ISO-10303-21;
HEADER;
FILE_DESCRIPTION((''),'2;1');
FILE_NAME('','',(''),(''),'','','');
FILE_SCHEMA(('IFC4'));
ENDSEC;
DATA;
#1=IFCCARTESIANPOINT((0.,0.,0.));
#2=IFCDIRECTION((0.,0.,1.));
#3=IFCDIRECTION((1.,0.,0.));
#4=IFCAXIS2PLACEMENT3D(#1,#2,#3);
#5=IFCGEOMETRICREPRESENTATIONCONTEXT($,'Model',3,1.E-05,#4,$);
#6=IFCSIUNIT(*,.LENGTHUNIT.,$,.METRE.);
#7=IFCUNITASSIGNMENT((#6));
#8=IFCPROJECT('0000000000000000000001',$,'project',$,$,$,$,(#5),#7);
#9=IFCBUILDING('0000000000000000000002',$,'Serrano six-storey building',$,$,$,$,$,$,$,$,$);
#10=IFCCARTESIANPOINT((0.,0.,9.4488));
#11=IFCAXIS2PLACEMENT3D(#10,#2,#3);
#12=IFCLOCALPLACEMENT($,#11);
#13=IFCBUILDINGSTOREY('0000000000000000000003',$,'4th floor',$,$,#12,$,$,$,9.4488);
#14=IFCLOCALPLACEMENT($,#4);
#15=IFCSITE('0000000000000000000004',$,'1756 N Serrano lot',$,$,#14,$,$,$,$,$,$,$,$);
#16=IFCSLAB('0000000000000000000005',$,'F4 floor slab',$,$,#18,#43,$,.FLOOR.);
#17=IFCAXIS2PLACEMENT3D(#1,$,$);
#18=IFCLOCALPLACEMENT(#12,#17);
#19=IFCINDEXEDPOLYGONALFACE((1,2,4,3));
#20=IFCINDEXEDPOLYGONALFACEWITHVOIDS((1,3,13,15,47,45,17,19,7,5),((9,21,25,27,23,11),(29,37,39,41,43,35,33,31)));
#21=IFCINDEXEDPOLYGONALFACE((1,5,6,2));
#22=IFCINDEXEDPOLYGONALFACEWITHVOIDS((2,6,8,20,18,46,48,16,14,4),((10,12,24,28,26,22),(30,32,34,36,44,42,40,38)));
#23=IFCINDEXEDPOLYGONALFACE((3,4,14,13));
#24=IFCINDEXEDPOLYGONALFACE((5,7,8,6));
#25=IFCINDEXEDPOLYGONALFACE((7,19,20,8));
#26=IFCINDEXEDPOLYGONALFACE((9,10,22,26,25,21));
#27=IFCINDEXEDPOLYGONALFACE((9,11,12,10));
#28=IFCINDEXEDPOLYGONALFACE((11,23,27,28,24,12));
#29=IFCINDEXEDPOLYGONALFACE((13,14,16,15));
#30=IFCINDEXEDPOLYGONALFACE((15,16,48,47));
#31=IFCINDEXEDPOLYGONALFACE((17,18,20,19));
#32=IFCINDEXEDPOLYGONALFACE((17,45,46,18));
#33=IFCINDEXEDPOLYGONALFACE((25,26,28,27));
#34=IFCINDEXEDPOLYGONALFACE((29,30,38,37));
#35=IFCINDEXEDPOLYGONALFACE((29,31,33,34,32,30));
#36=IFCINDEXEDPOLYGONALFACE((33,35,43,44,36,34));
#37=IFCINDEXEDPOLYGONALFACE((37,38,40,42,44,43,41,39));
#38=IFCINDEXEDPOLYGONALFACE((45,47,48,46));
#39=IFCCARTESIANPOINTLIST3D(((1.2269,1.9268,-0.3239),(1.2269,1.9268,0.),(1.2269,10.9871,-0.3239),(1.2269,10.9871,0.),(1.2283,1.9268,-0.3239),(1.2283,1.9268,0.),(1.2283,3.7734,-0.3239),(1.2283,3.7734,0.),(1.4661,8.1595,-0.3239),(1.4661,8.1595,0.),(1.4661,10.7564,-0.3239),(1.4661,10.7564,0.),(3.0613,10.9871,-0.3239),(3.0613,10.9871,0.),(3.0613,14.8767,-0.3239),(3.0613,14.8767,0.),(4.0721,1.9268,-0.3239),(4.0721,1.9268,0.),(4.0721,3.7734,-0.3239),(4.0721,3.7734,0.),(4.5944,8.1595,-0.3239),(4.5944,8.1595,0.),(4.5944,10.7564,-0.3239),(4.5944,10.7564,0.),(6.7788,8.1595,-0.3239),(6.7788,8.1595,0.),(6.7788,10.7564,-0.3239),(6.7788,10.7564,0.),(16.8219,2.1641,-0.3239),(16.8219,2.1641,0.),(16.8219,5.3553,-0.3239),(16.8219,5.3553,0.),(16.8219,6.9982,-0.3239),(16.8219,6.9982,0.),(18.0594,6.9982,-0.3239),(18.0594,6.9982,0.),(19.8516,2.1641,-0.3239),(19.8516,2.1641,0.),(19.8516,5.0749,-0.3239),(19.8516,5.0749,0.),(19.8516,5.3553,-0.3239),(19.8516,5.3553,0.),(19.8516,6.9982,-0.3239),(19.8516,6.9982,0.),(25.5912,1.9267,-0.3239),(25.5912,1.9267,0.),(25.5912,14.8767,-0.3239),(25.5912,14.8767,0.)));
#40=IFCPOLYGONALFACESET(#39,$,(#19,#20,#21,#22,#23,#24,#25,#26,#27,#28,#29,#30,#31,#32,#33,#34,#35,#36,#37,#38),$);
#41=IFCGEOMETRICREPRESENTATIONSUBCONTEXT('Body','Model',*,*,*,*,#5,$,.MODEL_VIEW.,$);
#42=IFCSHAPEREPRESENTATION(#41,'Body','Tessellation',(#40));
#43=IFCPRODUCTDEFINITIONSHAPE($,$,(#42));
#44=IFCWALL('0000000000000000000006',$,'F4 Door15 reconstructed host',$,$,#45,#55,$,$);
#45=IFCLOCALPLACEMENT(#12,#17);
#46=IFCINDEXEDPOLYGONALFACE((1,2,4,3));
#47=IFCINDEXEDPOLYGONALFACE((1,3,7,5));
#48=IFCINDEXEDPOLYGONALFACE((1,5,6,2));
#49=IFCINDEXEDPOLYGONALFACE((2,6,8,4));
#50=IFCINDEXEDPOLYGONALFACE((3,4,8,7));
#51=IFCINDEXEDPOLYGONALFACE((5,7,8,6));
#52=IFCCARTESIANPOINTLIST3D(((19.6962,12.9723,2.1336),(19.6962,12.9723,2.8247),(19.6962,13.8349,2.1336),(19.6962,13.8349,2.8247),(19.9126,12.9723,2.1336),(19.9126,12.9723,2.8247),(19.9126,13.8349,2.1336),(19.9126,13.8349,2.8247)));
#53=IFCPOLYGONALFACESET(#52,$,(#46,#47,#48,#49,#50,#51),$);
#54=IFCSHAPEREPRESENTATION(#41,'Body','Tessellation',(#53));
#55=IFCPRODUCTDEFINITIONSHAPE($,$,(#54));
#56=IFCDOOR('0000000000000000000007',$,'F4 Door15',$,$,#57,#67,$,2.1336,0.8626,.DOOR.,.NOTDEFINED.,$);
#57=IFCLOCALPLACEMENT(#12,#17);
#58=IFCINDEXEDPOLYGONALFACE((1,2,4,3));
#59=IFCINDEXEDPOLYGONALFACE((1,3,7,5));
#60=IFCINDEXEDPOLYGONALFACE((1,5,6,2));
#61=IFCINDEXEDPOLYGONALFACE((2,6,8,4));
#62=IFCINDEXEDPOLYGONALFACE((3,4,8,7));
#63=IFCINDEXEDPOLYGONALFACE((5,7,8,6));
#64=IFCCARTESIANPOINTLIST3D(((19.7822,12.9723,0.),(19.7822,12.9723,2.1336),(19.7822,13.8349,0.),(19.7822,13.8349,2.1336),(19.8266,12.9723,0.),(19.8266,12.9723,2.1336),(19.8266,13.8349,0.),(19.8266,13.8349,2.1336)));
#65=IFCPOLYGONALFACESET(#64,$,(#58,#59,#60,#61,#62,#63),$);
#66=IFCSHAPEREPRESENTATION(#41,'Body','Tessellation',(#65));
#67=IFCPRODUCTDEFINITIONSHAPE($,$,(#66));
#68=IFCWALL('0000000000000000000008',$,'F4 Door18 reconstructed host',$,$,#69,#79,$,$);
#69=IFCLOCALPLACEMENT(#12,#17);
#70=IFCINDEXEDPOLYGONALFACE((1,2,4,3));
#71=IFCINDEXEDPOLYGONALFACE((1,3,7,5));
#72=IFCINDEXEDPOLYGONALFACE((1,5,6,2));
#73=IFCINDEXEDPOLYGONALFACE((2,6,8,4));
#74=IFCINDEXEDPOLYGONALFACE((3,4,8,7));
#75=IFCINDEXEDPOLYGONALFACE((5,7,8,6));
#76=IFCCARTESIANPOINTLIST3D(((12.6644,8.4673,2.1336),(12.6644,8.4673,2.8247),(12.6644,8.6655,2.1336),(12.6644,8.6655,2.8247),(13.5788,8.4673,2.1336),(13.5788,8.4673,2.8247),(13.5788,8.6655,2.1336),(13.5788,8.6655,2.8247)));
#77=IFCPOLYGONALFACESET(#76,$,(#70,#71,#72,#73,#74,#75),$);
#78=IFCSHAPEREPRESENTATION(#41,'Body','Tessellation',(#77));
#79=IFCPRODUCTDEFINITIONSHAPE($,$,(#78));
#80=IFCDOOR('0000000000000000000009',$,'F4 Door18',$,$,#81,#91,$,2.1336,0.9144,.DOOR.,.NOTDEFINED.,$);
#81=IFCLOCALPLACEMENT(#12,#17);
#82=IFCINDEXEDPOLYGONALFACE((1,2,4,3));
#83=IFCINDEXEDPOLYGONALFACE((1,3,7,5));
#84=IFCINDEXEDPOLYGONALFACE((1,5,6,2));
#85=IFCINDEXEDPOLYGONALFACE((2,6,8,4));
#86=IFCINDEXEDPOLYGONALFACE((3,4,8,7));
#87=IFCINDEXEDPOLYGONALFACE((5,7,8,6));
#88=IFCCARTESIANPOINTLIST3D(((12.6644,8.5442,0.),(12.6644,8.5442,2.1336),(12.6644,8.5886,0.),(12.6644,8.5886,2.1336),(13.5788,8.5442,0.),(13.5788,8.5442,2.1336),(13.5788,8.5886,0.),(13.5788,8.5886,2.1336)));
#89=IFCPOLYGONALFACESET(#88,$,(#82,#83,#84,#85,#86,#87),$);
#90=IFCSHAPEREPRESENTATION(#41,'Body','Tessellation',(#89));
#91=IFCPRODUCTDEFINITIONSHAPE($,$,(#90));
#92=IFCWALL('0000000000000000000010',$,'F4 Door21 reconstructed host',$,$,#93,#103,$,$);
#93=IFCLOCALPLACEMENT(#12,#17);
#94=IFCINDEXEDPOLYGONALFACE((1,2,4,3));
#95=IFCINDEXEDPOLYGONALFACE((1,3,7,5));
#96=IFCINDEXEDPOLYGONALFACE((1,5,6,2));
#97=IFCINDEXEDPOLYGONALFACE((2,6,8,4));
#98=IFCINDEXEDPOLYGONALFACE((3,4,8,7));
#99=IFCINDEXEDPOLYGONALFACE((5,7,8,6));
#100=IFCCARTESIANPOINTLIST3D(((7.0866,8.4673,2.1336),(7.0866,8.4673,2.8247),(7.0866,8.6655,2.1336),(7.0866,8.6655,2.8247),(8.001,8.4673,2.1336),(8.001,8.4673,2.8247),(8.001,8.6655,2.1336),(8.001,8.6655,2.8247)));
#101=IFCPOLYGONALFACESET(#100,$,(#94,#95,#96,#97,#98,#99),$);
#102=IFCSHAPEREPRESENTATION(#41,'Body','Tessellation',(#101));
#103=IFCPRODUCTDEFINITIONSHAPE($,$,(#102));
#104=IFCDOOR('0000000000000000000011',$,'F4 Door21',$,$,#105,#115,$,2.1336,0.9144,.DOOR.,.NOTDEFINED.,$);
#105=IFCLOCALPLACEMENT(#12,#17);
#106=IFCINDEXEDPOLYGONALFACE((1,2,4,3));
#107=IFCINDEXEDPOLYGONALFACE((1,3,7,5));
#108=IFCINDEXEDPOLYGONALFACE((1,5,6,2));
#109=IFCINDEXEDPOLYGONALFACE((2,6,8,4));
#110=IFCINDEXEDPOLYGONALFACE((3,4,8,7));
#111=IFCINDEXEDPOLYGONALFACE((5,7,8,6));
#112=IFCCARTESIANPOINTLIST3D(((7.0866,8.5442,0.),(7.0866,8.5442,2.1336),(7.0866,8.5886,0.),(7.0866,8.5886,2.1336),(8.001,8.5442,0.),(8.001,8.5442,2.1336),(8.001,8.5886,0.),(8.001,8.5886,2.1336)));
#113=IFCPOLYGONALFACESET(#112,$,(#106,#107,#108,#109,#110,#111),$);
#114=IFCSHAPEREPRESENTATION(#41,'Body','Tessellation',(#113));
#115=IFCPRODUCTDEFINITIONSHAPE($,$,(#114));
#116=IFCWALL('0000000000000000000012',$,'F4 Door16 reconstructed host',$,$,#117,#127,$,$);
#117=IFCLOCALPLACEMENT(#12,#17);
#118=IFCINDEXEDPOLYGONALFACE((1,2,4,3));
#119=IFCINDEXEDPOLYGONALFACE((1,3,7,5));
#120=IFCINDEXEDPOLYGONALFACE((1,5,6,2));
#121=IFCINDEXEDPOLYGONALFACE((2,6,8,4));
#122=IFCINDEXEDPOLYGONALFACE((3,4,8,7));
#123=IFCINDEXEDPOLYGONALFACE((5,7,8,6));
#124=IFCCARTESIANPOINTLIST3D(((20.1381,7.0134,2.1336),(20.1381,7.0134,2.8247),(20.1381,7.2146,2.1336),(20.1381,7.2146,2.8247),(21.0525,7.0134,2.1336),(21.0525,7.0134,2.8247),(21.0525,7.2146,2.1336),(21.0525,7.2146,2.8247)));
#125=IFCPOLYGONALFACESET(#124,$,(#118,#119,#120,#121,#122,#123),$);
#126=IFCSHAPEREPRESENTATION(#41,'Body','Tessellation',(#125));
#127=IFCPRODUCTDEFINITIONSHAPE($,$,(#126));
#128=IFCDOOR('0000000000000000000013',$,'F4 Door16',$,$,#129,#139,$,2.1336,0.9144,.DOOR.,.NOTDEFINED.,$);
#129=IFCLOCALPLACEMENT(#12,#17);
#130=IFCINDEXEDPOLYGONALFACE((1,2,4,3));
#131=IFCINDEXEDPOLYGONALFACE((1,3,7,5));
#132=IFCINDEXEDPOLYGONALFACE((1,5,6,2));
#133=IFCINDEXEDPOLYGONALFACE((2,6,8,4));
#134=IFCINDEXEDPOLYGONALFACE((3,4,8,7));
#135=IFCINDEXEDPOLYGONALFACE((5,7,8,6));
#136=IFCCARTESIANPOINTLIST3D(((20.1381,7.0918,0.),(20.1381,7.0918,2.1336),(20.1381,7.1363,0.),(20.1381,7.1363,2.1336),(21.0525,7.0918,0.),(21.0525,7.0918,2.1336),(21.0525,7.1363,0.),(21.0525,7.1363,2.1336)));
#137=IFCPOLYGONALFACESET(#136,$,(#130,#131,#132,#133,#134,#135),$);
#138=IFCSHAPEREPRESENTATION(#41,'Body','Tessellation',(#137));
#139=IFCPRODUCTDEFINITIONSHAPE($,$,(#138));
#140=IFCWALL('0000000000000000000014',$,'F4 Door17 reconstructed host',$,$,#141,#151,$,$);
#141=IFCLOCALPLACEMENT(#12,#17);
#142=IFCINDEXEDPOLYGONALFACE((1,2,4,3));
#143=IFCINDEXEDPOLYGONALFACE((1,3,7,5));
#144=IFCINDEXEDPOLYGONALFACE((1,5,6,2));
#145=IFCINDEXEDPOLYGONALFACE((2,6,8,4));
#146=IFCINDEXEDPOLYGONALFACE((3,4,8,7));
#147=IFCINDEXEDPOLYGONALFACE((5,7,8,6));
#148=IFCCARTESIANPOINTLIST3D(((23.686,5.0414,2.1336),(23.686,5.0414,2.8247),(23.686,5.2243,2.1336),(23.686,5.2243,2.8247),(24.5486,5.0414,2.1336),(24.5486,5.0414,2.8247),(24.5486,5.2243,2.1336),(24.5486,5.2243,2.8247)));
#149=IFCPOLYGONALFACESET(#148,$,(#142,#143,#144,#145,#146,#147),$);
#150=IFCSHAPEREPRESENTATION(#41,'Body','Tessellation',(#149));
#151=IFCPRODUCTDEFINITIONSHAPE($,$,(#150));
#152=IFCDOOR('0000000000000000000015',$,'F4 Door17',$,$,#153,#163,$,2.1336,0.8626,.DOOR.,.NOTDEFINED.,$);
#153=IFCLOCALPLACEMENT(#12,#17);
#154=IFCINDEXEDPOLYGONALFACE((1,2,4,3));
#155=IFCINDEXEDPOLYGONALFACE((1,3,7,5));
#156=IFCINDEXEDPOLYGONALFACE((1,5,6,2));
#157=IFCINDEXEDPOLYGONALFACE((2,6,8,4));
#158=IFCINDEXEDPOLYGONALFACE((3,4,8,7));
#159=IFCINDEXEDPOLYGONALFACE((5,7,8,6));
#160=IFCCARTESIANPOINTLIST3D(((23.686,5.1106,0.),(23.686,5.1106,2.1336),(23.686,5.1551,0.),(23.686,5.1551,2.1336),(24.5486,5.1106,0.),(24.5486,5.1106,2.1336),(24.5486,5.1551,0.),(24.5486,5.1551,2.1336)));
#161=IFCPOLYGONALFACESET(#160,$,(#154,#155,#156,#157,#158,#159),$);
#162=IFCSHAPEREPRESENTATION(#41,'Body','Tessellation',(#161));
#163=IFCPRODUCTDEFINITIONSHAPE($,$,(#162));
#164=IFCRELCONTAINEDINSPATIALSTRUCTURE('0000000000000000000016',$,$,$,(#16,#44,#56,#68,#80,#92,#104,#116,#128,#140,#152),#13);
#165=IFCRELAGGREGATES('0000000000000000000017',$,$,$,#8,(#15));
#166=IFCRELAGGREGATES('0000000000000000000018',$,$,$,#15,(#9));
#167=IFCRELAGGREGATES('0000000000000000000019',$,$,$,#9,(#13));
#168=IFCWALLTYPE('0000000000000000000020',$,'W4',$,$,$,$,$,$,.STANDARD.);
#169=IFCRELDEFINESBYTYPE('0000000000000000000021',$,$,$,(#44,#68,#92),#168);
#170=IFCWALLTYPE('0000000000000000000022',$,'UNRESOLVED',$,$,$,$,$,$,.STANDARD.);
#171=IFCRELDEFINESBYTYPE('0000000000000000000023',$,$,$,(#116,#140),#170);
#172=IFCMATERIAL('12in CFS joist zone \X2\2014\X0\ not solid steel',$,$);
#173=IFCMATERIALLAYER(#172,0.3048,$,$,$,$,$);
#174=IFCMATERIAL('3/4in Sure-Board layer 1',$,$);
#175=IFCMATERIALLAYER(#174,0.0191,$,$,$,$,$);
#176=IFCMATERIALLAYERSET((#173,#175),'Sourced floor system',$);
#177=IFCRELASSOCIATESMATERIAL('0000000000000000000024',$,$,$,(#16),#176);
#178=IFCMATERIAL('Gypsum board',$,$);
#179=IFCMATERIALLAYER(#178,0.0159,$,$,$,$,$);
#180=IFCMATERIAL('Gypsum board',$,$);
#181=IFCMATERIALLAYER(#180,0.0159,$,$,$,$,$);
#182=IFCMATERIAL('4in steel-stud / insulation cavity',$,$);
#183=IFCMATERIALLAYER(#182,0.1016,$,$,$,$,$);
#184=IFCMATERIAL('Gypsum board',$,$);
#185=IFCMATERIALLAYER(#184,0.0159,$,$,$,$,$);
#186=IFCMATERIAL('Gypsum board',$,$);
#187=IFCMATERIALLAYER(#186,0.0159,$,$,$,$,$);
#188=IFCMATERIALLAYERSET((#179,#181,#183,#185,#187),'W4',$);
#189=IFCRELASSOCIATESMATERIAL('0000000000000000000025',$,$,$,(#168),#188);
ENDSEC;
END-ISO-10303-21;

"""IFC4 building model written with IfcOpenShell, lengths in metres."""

from ifc_helpers import new_model, si_unit, frame, origin_with_axes, place, context, subcontext, project, spatial, polyline, outline, extrude, material, layer, layer_set, type_object, element, fill, save


model = new_model("IFC4")

# Units and contexts
model_context = context("Model", 3, precision=1e-05, world=origin_with_axes())
body_context = subcontext(model_context, "Body", "Model", "MODEL_VIEW")
ifc_project = project(units=[si_unit("LENGTHUNIT", "METRE")], contexts=[model_context])

# Site, building, storey
site_placement = place(None, origin_with_axes())
site = spatial("IfcSite", under=ifc_project, at=site_placement, Name="1756 N Serrano lot")
building = spatial("IfcBuilding", under=site, Name="Serrano six-storey building")
storey_placement = place(None, frame((0.0, 0.0, 9.4488), z_axis=(0.0, 0.0, 1.0), x_axis=(1.0, 0.0, 0.0)))
storey = spatial("IfcBuildingStorey", under=building, at=storey_placement, Name="4th floor", Elevation=9.4488)

# Slab
ifc_material_1 = material(Name="12in CFS joist zone — not solid steel")
ifc_layer_1 = layer(ifc_material_1, 0.3048)
ifc_material_2 = material(Name="3/4in Sure-Board layer 1")
ifc_layer_2 = layer(ifc_material_2, 0.0191)
ifc_layer_set_1 = layer_set([ifc_layer_1, ifc_layer_2], Name="Sourced floor system")
slab_placement = place(storey_placement, frame((0.0, 0.0, -9.4488), z_axis=(0.0, 0.0, 1.0), x_axis=(1.0, 0.0, 0.0)))
element("IfcSlab", 1, at=slab_placement, inside=storey, material=ifc_layer_set_1, Name="F4 floor slab", PredefinedType="FLOOR", context=body_context, shape_type="SweptSolid", body=[
    extrude(outline(polyline([(3.0613, 14.8767), (25.5912, 14.8767), (25.5912, 1.9267), (4.0721, 1.9268), (4.0721, 3.7734), (1.2283, 3.7734), (1.2283, 1.9268), (1.2269, 1.9268), (1.2269, 10.9871), (3.0613, 10.9871), (3.0613, 14.8767)]), holes=[polyline([(6.7788, 10.7564), (4.5944, 10.7564), (1.4661, 10.7564), (1.4661, 8.1595), (4.5944, 8.1595), (6.7788, 8.1595), (6.7788, 10.7564)]), polyline([(16.8219, 5.3553), (16.8219, 2.1641), (19.8516, 2.1641), (19.8516, 5.0749), (19.8516, 5.3553), (19.8516, 6.9982), (18.0594, 6.9982), (16.8219, 6.9982), (16.8219, 5.3553)])]), frame((0.0, 0.0, 9.125)), (0.0, 0.0, 1.0), 0.3239),
])

# Walls, openings, doors
ifc_material_3 = material(Name="Gypsum board")
ifc_layer_3 = layer(ifc_material_3, 0.0159)
ifc_material_4 = material(Name="Gypsum board")
ifc_layer_4 = layer(ifc_material_4, 0.0159)
ifc_material_5 = material(Name="4in steel-stud / insulation cavity")
ifc_layer_5 = layer(ifc_material_5, 0.1016)
ifc_material_6 = material(Name="Gypsum board")
ifc_layer_6 = layer(ifc_material_6, 0.0159)
ifc_material_7 = material(Name="Gypsum board")
ifc_layer_7 = layer(ifc_material_7, 0.0159)
ifc_layer_set_2 = layer_set([ifc_layer_3, ifc_layer_4, ifc_layer_5, ifc_layer_6, ifc_layer_7], Name="W4")
wall_type_1 = type_object("IfcWallType", Name="W4", PredefinedType="STANDARD", material=ifc_layer_set_2)
wall_1_placement = place(storey_placement, frame((0.0, 0.0, -9.4488), z_axis=(0.0, 0.0, 1.0), x_axis=(1.0, 0.0, 0.0)))
wall_1 = element("IfcWall", 2, at=wall_1_placement, inside=storey, type_object=wall_type_1, Name="F4 Door15 reconstructed host", context=body_context, shape_type="SweptSolid", body=[
    extrude(outline(polyline([(19.9126, 12.9723), (19.6962, 12.9723), (19.6962, 13.8349), (19.9126, 13.8349), (19.9126, 12.9723)])), frame((0.0, 0.0, 9.4488)), (0.0, 0.0, 1.0), 2.8247),
])
opening_1_placement = place(None, origin_with_axes())
opening_1 = element("IfcOpeningElement", 3, at=opening_1_placement, cuts=wall_1, PredefinedType="OPENING", context=body_context, shape_type="SweptSolid", body=[
    extrude(outline(polyline([(19.9309, 12.9723), (19.6779, 12.9723), (19.6779, 13.8349), (19.9309, 13.8349), (19.9309, 12.9723)])), frame((0.0, 0.0, 9.4488)), (0.0, 0.0, 1.0), 2.1336),
])
door_1_placement = place(storey_placement, frame((0.0, 0.0, -9.4488), z_axis=(0.0, 0.0, 1.0), x_axis=(1.0, 0.0, 0.0)))
door_1 = element("IfcDoor", 4, at=door_1_placement, inside=storey, Name="F4 Door15", OperationType="NOTDEFINED", OverallHeight=2.1336, OverallWidth=0.8626, PredefinedType="DOOR", context=body_context, shape_type="SweptSolid", body=[
    extrude(outline(polyline([(19.8266, 12.9723), (19.7822, 12.9723), (19.7822, 13.8349), (19.8266, 13.8349), (19.8266, 12.9723)])), frame((0.0, 0.0, 9.4488)), (0.0, 0.0, 1.0), 2.1336),
])
fill(opening_1, door_1)
wall_2_placement = place(storey_placement, frame((0.0, 0.0, -9.4488), z_axis=(0.0, 0.0, 1.0), x_axis=(1.0, 0.0, 0.0)))
wall_2 = element("IfcWall", 5, at=wall_2_placement, inside=storey, type_object=wall_type_1, Name="F4 Door18 reconstructed host", context=body_context, shape_type="SweptSolid", body=[
    extrude(outline(polyline([(13.5788, 8.6655), (13.5788, 8.4673), (12.6644, 8.4673), (12.6644, 8.6655), (13.5788, 8.6655)])), frame((0.0, 0.0, 9.4488)), (0.0, 0.0, 1.0), 2.8247),
])
opening_2_placement = place(None, origin_with_axes())
opening_2 = element("IfcOpeningElement", 6, at=opening_2_placement, cuts=wall_2, PredefinedType="OPENING", context=body_context, shape_type="SweptSolid", body=[
    extrude(outline(polyline([(13.5788, 8.6838), (13.5788, 8.4491), (12.6644, 8.4491), (12.6644, 8.6838), (13.5788, 8.6838)])), frame((0.0, 0.0, 9.4488)), (0.0, 0.0, 1.0), 2.1336),
])
door_2_placement = place(storey_placement, frame((0.0, 0.0, -9.4488), z_axis=(0.0, 0.0, 1.0), x_axis=(1.0, 0.0, 0.0)))
door_2 = element("IfcDoor", 7, at=door_2_placement, inside=storey, Name="F4 Door18", OperationType="NOTDEFINED", OverallHeight=2.1336, OverallWidth=0.9144, PredefinedType="DOOR", context=body_context, shape_type="SweptSolid", body=[
    extrude(outline(polyline([(13.5788, 8.5886), (13.5788, 8.5442), (12.6644, 8.5442), (12.6644, 8.5886), (13.5788, 8.5886)])), frame((0.0, 0.0, 9.4488)), (0.0, 0.0, 1.0), 2.1336),
])
fill(opening_2, door_2)
wall_3_placement = place(storey_placement, frame((0.0, 0.0, -9.4488), z_axis=(0.0, 0.0, 1.0), x_axis=(1.0, 0.0, 0.0)))
wall_3 = element("IfcWall", 8, at=wall_3_placement, inside=storey, type_object=wall_type_1, Name="F4 Door21 reconstructed host", context=body_context, shape_type="SweptSolid", body=[
    extrude(outline(polyline([(8.001, 8.6655), (8.001, 8.4673), (7.0866, 8.4673), (7.0866, 8.6655), (8.001, 8.6655)])), frame((0.0, 0.0, 9.4488)), (0.0, 0.0, 1.0), 2.8247),
])
opening_3_placement = place(None, origin_with_axes())
opening_3 = element("IfcOpeningElement", 9, at=opening_3_placement, cuts=wall_3, PredefinedType="OPENING", context=body_context, shape_type="SweptSolid", body=[
    extrude(outline(polyline([(8.001, 8.6838), (8.001, 8.4491), (7.0866, 8.4491), (7.0866, 8.6838), (8.001, 8.6838)])), frame((0.0, 0.0, 9.4488)), (0.0, 0.0, 1.0), 2.1336),
])
door_3_placement = place(storey_placement, frame((0.0, 0.0, -9.4488), z_axis=(0.0, 0.0, 1.0), x_axis=(1.0, 0.0, 0.0)))
door_3 = element("IfcDoor", 10, at=door_3_placement, inside=storey, Name="F4 Door21", OperationType="NOTDEFINED", OverallHeight=2.1336, OverallWidth=0.9144, PredefinedType="DOOR", context=body_context, shape_type="SweptSolid", body=[
    extrude(outline(polyline([(8.001, 8.5886), (8.001, 8.5442), (7.0866, 8.5442), (7.0866, 8.5886), (8.001, 8.5886)])), frame((0.0, 0.0, 9.4488)), (0.0, 0.0, 1.0), 2.1336),
])
fill(opening_3, door_3)
wall_type_2 = type_object("IfcWallType", Name="UNRESOLVED", PredefinedType="STANDARD")
wall_4_placement = place(storey_placement, frame((0.0, 0.0, -9.4488), z_axis=(0.0, 0.0, 1.0), x_axis=(1.0, 0.0, 0.0)))
wall_4 = element("IfcWall", 11, at=wall_4_placement, inside=storey, type_object=wall_type_2, Name="F4 Door16 reconstructed host", context=body_context, shape_type="SweptSolid", body=[
    extrude(outline(polyline([(21.0525, 7.2146), (21.0525, 7.0134), (20.1381, 7.0134), (20.1381, 7.2146), (21.0525, 7.2146)])), frame((0.0, 0.0, 9.4488)), (0.0, 0.0, 1.0), 2.8247),
])
opening_4_placement = place(None, origin_with_axes())
opening_4 = element("IfcOpeningElement", 12, at=opening_4_placement, cuts=wall_4, PredefinedType="OPENING", context=body_context, shape_type="SweptSolid", body=[
    extrude(outline(polyline([(21.0525, 7.2329), (21.0525, 6.9952), (20.1381, 6.9952), (20.1381, 7.2329), (21.0525, 7.2329)])), frame((0.0, 0.0, 9.4488)), (0.0, 0.0, 1.0), 2.1336),
])
door_4_placement = place(storey_placement, frame((0.0, 0.0, -9.4488), z_axis=(0.0, 0.0, 1.0), x_axis=(1.0, 0.0, 0.0)))
door_4 = element("IfcDoor", 13, at=door_4_placement, inside=storey, Name="F4 Door16", OperationType="NOTDEFINED", OverallHeight=2.1336, OverallWidth=0.9144, PredefinedType="DOOR", context=body_context, shape_type="SweptSolid", body=[
    extrude(outline(polyline([(21.0525, 7.1363), (21.0525, 7.0918), (20.1381, 7.0918), (20.1381, 7.1363), (21.0525, 7.1363)])), frame((0.0, 0.0, 9.4488)), (0.0, 0.0, 1.0), 2.1336),
])
fill(opening_4, door_4)
wall_5_placement = place(storey_placement, frame((0.0, 0.0, -9.4488), z_axis=(0.0, 0.0, 1.0), x_axis=(1.0, 0.0, 0.0)))
wall_5 = element("IfcWall", 14, at=wall_5_placement, inside=storey, type_object=wall_type_2, Name="F4 Door17 reconstructed host", context=body_context, shape_type="SweptSolid", body=[
    extrude(outline(polyline([(23.686, 5.0414), (23.686, 5.2243), (24.5486, 5.2243), (24.5486, 5.0414), (23.686, 5.0414)])), frame((0.0, 0.0, 9.4488)), (0.0, 0.0, 1.0), 2.8247),
])
opening_5_placement = place(None, origin_with_axes())
opening_5 = element("IfcOpeningElement", 15, at=opening_5_placement, cuts=wall_5, PredefinedType="OPENING", context=body_context, shape_type="SweptSolid", body=[
    extrude(outline(polyline([(23.686, 5.0231), (23.686, 5.2426), (24.5486, 5.2426), (24.5486, 5.0231), (23.686, 5.0231)])), frame((0.0, 0.0, 9.4488)), (0.0, 0.0, 1.0), 2.1336),
])
door_5_placement = place(storey_placement, frame((0.0, 0.0, -9.4488), z_axis=(0.0, 0.0, 1.0), x_axis=(1.0, 0.0, 0.0)))
door_5 = element("IfcDoor", 16, at=door_5_placement, inside=storey, Name="F4 Door17", OperationType="NOTDEFINED", OverallHeight=2.1336, OverallWidth=0.8626, PredefinedType="DOOR", context=body_context, shape_type="SweptSolid", body=[
    extrude(outline(polyline([(23.686, 5.1106), (23.686, 5.1551), (24.5486, 5.1551), (24.5486, 5.1106), (23.686, 5.1106)])), frame((0.0, 0.0, 9.4488)), (0.0, 0.0, 1.0), 2.1336),
])
fill(opening_5, door_5)

save(model, "model.ifc")
